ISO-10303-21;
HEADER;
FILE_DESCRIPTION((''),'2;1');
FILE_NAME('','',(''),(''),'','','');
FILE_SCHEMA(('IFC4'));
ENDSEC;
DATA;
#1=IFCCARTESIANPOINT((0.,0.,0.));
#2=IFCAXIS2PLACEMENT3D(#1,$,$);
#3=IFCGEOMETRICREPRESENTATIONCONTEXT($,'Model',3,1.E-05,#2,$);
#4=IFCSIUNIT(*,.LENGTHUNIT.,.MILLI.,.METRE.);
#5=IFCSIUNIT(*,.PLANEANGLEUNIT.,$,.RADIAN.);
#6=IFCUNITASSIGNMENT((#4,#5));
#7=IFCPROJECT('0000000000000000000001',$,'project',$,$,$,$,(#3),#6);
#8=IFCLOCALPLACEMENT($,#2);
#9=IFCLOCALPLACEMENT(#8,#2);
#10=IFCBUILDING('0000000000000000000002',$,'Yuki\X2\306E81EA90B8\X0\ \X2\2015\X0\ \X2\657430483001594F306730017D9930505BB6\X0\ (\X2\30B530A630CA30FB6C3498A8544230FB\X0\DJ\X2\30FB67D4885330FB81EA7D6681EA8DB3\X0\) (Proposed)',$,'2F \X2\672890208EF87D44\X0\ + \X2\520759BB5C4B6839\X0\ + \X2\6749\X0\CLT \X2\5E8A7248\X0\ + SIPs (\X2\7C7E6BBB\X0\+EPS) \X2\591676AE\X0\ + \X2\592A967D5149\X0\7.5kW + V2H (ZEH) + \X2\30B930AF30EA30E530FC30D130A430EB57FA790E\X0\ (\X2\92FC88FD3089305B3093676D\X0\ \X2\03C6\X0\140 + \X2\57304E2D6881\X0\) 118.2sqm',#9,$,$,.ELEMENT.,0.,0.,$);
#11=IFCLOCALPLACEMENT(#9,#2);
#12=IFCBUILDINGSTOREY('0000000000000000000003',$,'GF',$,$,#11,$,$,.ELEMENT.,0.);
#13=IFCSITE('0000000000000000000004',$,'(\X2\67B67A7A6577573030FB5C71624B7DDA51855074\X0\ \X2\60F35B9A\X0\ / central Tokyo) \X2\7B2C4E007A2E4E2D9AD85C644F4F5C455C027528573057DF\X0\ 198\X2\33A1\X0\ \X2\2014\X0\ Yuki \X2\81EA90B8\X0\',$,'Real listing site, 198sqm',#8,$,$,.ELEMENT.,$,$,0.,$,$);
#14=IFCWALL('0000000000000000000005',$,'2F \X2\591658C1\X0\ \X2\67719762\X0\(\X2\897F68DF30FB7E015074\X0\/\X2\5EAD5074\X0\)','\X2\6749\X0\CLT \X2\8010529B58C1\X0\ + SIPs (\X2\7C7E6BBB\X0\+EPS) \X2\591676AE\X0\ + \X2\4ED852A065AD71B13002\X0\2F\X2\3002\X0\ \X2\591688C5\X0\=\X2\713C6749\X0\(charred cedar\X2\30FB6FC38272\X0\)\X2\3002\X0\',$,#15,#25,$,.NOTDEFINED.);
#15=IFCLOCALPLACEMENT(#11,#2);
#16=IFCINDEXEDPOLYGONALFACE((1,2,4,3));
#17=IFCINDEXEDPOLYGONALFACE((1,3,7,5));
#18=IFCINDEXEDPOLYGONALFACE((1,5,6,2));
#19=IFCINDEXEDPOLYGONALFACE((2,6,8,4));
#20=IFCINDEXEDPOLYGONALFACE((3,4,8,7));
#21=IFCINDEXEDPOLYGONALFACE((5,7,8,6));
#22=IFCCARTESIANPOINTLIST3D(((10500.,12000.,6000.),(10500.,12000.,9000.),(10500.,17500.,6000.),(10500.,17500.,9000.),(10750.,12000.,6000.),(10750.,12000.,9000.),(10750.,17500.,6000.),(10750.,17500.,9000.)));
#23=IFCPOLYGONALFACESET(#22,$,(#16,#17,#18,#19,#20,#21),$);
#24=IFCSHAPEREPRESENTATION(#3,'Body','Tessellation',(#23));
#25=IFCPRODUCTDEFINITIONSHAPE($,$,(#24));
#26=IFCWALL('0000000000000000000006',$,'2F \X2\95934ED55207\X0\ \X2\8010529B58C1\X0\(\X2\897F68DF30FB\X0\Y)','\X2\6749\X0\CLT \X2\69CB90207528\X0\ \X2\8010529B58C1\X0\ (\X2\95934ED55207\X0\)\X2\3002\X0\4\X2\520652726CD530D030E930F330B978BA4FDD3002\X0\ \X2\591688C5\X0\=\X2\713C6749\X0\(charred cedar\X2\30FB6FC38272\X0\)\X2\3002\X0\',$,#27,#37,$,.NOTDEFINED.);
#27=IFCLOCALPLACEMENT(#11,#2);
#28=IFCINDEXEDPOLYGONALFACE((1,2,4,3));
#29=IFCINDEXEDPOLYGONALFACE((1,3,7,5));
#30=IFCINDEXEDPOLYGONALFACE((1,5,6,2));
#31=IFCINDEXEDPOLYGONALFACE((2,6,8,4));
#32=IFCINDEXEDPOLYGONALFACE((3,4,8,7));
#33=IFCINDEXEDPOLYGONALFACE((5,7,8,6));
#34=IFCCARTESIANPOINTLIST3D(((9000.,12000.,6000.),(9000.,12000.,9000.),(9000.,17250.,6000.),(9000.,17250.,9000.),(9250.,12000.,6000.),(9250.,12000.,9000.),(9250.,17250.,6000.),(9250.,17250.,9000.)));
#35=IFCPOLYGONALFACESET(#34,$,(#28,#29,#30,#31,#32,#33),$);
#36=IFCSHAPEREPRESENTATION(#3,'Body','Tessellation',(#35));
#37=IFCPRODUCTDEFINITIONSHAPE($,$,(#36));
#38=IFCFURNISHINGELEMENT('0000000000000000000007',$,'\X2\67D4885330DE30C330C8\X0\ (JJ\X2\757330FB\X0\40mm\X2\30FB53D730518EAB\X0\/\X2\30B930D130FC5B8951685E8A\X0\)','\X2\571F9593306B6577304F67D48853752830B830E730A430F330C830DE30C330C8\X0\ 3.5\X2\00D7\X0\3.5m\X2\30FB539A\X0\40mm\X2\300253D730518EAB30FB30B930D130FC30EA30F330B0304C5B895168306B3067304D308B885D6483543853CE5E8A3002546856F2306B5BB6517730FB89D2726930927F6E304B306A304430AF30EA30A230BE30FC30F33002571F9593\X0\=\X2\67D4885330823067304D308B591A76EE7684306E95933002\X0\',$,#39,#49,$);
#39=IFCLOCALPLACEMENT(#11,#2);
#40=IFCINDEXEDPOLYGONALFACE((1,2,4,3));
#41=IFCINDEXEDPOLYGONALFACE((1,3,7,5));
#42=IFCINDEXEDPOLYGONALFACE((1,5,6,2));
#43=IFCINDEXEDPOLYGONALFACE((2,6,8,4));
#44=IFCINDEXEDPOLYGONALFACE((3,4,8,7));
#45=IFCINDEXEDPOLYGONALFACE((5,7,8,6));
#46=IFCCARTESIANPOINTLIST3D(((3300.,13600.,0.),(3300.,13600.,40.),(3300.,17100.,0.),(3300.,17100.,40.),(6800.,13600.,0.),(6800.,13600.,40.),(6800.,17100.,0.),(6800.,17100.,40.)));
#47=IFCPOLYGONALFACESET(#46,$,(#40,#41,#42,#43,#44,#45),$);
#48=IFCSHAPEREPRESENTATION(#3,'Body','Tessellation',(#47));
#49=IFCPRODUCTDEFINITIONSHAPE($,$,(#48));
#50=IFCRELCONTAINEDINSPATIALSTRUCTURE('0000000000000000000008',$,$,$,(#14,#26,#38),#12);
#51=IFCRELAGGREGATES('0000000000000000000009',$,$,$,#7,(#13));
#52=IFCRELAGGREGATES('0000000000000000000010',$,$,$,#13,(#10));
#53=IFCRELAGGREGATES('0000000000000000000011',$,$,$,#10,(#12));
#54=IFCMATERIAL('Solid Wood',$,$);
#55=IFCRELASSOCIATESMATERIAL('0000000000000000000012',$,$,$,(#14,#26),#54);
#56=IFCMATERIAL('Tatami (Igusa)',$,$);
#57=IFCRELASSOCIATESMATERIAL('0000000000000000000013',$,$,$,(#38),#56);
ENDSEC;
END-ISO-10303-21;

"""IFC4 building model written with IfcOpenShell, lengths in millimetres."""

from ifc_helpers import new_model, si_unit, frame, frame_2d, origin, place, context, project, spatial, rectangle, extrude, material, element, save


model = new_model("IFC4")

# Units and contexts
model_context = context("Model", 3, precision=1e-05, world=origin())
ifc_project = project(units=[si_unit("LENGTHUNIT", "METRE", prefix="MILLI"), si_unit("PLANEANGLEUNIT", "RADIAN")], contexts=[model_context])

# Site, building, storey
site_placement = place(None, origin())
site = spatial("IfcSite", under=ifc_project, at=site_placement, Name="(架空敷地・山手線内側 想定 / central Tokyo) 第一種中高層住居専用地域 198㎡ — Yuki 自邸", ObjectType="Real listing site, 198sqm", CompositionType="ELEMENT", RefElevation=0.0)
building_placement = place(site_placement, origin())
building = spatial("IfcBuilding", under=site, at=building_placement, Name="Yukiの自邸 ― 整え、奏で、継ぐ家 (サウナ・水風呂・DJ・柔術・自給自足) (Proposed)", ObjectType="2F 木造軸組 + 切妻屋根 + 杉CLT 床版 + SIPs (籾殻+EPS) 外皮 + 太陽光7.5kW + V2H (ZEH) + スクリューパイル基礎 (鋼製らせん杭 φ140 + 地中梁) 118.2sqm", CompositionType="ELEMENT", ElevationOfRefHeight=0.0, ElevationOfTerrain=0.0)
storey_placement = place(building_placement, origin())
storey = spatial("IfcBuildingStorey", under=building, at=storey_placement, Name="GF", CompositionType="ELEMENT", Elevation=0.0)

# Shared definitions
ifc_material_1 = material(Name="Solid Wood")

# Walls
wall_1_placement = place(storey_placement, frame((5250.0, 6000.0, 3000.0)))
element("IfcWall", 1, at=wall_1_placement, inside=storey, material=ifc_material_1, Name="2F 外壁 東面(西棟・縁側/庭側)", Description="杉CLT 耐力壁 + SIPs (籾殻+EPS) 外皮 + 付加断熱。2F。 外装=焼杉(charred cedar・濃色)。", PredefinedType="NOTDEFINED", context=model_context, shape_type="SweptSolid", body=[
    extrude(rectangle(XDim=250.0, YDim=5500.0, at=frame_2d((125.0, 2750.0))), frame((5250.0, 6000.0, 3000.0)), (0.0, 0.0, 1.0), 3000.0),
])
wall_2_placement = place(storey_placement, frame((4500.0, 6000.0, 3000.0)))
element("IfcWall", 2, at=wall_2_placement, inside=storey, material=ifc_material_1, Name="2F 間仕切 耐力壁(西棟・Y)", Description="杉CLT 構造用 耐力壁 (間仕切)。4分割法バランス確保。 外装=焼杉(charred cedar・濃色)。", PredefinedType="NOTDEFINED", context=model_context, shape_type="SweptSolid", body=[
    extrude(rectangle(XDim=250.0, YDim=5250.0, at=frame_2d((125.0, 2625.0))), frame((4500.0, 6000.0, 3000.0)), (0.0, 0.0, 1.0), 3000.0),
])

# Furnishing element
ifc_material_2 = material(Name="Tatami (Igusa)")
furnishing_1_placement = place(storey_placement, frame((1650.0, 6800.0, 0.0)))
element("IfcFurnishingElement", 3, at=furnishing_1_placement, inside=storey, material=ifc_material_2, Name="柔術マット (JJ畳・40mm・受け身/スパー安全床)", Description="土間に敷く柔術用ジョイントマット 3.5×3.5m・厚40mm。受け身・スパーリングが安全にできる衝撃吸収床。周囲に家具・角物を置かないクリアゾーン。土間=柔術もできる多目的の間。", context=model_context, shape_type="SweptSolid", body=[
    extrude(rectangle(XDim=3500.0, YDim=3500.0, at=frame_2d((1750.0, 1750.0))), frame((1650.0, 6800.0, 0.0)), (0.0, 0.0, 1.0), 40.0),
])

save(model, "model.ifc")
